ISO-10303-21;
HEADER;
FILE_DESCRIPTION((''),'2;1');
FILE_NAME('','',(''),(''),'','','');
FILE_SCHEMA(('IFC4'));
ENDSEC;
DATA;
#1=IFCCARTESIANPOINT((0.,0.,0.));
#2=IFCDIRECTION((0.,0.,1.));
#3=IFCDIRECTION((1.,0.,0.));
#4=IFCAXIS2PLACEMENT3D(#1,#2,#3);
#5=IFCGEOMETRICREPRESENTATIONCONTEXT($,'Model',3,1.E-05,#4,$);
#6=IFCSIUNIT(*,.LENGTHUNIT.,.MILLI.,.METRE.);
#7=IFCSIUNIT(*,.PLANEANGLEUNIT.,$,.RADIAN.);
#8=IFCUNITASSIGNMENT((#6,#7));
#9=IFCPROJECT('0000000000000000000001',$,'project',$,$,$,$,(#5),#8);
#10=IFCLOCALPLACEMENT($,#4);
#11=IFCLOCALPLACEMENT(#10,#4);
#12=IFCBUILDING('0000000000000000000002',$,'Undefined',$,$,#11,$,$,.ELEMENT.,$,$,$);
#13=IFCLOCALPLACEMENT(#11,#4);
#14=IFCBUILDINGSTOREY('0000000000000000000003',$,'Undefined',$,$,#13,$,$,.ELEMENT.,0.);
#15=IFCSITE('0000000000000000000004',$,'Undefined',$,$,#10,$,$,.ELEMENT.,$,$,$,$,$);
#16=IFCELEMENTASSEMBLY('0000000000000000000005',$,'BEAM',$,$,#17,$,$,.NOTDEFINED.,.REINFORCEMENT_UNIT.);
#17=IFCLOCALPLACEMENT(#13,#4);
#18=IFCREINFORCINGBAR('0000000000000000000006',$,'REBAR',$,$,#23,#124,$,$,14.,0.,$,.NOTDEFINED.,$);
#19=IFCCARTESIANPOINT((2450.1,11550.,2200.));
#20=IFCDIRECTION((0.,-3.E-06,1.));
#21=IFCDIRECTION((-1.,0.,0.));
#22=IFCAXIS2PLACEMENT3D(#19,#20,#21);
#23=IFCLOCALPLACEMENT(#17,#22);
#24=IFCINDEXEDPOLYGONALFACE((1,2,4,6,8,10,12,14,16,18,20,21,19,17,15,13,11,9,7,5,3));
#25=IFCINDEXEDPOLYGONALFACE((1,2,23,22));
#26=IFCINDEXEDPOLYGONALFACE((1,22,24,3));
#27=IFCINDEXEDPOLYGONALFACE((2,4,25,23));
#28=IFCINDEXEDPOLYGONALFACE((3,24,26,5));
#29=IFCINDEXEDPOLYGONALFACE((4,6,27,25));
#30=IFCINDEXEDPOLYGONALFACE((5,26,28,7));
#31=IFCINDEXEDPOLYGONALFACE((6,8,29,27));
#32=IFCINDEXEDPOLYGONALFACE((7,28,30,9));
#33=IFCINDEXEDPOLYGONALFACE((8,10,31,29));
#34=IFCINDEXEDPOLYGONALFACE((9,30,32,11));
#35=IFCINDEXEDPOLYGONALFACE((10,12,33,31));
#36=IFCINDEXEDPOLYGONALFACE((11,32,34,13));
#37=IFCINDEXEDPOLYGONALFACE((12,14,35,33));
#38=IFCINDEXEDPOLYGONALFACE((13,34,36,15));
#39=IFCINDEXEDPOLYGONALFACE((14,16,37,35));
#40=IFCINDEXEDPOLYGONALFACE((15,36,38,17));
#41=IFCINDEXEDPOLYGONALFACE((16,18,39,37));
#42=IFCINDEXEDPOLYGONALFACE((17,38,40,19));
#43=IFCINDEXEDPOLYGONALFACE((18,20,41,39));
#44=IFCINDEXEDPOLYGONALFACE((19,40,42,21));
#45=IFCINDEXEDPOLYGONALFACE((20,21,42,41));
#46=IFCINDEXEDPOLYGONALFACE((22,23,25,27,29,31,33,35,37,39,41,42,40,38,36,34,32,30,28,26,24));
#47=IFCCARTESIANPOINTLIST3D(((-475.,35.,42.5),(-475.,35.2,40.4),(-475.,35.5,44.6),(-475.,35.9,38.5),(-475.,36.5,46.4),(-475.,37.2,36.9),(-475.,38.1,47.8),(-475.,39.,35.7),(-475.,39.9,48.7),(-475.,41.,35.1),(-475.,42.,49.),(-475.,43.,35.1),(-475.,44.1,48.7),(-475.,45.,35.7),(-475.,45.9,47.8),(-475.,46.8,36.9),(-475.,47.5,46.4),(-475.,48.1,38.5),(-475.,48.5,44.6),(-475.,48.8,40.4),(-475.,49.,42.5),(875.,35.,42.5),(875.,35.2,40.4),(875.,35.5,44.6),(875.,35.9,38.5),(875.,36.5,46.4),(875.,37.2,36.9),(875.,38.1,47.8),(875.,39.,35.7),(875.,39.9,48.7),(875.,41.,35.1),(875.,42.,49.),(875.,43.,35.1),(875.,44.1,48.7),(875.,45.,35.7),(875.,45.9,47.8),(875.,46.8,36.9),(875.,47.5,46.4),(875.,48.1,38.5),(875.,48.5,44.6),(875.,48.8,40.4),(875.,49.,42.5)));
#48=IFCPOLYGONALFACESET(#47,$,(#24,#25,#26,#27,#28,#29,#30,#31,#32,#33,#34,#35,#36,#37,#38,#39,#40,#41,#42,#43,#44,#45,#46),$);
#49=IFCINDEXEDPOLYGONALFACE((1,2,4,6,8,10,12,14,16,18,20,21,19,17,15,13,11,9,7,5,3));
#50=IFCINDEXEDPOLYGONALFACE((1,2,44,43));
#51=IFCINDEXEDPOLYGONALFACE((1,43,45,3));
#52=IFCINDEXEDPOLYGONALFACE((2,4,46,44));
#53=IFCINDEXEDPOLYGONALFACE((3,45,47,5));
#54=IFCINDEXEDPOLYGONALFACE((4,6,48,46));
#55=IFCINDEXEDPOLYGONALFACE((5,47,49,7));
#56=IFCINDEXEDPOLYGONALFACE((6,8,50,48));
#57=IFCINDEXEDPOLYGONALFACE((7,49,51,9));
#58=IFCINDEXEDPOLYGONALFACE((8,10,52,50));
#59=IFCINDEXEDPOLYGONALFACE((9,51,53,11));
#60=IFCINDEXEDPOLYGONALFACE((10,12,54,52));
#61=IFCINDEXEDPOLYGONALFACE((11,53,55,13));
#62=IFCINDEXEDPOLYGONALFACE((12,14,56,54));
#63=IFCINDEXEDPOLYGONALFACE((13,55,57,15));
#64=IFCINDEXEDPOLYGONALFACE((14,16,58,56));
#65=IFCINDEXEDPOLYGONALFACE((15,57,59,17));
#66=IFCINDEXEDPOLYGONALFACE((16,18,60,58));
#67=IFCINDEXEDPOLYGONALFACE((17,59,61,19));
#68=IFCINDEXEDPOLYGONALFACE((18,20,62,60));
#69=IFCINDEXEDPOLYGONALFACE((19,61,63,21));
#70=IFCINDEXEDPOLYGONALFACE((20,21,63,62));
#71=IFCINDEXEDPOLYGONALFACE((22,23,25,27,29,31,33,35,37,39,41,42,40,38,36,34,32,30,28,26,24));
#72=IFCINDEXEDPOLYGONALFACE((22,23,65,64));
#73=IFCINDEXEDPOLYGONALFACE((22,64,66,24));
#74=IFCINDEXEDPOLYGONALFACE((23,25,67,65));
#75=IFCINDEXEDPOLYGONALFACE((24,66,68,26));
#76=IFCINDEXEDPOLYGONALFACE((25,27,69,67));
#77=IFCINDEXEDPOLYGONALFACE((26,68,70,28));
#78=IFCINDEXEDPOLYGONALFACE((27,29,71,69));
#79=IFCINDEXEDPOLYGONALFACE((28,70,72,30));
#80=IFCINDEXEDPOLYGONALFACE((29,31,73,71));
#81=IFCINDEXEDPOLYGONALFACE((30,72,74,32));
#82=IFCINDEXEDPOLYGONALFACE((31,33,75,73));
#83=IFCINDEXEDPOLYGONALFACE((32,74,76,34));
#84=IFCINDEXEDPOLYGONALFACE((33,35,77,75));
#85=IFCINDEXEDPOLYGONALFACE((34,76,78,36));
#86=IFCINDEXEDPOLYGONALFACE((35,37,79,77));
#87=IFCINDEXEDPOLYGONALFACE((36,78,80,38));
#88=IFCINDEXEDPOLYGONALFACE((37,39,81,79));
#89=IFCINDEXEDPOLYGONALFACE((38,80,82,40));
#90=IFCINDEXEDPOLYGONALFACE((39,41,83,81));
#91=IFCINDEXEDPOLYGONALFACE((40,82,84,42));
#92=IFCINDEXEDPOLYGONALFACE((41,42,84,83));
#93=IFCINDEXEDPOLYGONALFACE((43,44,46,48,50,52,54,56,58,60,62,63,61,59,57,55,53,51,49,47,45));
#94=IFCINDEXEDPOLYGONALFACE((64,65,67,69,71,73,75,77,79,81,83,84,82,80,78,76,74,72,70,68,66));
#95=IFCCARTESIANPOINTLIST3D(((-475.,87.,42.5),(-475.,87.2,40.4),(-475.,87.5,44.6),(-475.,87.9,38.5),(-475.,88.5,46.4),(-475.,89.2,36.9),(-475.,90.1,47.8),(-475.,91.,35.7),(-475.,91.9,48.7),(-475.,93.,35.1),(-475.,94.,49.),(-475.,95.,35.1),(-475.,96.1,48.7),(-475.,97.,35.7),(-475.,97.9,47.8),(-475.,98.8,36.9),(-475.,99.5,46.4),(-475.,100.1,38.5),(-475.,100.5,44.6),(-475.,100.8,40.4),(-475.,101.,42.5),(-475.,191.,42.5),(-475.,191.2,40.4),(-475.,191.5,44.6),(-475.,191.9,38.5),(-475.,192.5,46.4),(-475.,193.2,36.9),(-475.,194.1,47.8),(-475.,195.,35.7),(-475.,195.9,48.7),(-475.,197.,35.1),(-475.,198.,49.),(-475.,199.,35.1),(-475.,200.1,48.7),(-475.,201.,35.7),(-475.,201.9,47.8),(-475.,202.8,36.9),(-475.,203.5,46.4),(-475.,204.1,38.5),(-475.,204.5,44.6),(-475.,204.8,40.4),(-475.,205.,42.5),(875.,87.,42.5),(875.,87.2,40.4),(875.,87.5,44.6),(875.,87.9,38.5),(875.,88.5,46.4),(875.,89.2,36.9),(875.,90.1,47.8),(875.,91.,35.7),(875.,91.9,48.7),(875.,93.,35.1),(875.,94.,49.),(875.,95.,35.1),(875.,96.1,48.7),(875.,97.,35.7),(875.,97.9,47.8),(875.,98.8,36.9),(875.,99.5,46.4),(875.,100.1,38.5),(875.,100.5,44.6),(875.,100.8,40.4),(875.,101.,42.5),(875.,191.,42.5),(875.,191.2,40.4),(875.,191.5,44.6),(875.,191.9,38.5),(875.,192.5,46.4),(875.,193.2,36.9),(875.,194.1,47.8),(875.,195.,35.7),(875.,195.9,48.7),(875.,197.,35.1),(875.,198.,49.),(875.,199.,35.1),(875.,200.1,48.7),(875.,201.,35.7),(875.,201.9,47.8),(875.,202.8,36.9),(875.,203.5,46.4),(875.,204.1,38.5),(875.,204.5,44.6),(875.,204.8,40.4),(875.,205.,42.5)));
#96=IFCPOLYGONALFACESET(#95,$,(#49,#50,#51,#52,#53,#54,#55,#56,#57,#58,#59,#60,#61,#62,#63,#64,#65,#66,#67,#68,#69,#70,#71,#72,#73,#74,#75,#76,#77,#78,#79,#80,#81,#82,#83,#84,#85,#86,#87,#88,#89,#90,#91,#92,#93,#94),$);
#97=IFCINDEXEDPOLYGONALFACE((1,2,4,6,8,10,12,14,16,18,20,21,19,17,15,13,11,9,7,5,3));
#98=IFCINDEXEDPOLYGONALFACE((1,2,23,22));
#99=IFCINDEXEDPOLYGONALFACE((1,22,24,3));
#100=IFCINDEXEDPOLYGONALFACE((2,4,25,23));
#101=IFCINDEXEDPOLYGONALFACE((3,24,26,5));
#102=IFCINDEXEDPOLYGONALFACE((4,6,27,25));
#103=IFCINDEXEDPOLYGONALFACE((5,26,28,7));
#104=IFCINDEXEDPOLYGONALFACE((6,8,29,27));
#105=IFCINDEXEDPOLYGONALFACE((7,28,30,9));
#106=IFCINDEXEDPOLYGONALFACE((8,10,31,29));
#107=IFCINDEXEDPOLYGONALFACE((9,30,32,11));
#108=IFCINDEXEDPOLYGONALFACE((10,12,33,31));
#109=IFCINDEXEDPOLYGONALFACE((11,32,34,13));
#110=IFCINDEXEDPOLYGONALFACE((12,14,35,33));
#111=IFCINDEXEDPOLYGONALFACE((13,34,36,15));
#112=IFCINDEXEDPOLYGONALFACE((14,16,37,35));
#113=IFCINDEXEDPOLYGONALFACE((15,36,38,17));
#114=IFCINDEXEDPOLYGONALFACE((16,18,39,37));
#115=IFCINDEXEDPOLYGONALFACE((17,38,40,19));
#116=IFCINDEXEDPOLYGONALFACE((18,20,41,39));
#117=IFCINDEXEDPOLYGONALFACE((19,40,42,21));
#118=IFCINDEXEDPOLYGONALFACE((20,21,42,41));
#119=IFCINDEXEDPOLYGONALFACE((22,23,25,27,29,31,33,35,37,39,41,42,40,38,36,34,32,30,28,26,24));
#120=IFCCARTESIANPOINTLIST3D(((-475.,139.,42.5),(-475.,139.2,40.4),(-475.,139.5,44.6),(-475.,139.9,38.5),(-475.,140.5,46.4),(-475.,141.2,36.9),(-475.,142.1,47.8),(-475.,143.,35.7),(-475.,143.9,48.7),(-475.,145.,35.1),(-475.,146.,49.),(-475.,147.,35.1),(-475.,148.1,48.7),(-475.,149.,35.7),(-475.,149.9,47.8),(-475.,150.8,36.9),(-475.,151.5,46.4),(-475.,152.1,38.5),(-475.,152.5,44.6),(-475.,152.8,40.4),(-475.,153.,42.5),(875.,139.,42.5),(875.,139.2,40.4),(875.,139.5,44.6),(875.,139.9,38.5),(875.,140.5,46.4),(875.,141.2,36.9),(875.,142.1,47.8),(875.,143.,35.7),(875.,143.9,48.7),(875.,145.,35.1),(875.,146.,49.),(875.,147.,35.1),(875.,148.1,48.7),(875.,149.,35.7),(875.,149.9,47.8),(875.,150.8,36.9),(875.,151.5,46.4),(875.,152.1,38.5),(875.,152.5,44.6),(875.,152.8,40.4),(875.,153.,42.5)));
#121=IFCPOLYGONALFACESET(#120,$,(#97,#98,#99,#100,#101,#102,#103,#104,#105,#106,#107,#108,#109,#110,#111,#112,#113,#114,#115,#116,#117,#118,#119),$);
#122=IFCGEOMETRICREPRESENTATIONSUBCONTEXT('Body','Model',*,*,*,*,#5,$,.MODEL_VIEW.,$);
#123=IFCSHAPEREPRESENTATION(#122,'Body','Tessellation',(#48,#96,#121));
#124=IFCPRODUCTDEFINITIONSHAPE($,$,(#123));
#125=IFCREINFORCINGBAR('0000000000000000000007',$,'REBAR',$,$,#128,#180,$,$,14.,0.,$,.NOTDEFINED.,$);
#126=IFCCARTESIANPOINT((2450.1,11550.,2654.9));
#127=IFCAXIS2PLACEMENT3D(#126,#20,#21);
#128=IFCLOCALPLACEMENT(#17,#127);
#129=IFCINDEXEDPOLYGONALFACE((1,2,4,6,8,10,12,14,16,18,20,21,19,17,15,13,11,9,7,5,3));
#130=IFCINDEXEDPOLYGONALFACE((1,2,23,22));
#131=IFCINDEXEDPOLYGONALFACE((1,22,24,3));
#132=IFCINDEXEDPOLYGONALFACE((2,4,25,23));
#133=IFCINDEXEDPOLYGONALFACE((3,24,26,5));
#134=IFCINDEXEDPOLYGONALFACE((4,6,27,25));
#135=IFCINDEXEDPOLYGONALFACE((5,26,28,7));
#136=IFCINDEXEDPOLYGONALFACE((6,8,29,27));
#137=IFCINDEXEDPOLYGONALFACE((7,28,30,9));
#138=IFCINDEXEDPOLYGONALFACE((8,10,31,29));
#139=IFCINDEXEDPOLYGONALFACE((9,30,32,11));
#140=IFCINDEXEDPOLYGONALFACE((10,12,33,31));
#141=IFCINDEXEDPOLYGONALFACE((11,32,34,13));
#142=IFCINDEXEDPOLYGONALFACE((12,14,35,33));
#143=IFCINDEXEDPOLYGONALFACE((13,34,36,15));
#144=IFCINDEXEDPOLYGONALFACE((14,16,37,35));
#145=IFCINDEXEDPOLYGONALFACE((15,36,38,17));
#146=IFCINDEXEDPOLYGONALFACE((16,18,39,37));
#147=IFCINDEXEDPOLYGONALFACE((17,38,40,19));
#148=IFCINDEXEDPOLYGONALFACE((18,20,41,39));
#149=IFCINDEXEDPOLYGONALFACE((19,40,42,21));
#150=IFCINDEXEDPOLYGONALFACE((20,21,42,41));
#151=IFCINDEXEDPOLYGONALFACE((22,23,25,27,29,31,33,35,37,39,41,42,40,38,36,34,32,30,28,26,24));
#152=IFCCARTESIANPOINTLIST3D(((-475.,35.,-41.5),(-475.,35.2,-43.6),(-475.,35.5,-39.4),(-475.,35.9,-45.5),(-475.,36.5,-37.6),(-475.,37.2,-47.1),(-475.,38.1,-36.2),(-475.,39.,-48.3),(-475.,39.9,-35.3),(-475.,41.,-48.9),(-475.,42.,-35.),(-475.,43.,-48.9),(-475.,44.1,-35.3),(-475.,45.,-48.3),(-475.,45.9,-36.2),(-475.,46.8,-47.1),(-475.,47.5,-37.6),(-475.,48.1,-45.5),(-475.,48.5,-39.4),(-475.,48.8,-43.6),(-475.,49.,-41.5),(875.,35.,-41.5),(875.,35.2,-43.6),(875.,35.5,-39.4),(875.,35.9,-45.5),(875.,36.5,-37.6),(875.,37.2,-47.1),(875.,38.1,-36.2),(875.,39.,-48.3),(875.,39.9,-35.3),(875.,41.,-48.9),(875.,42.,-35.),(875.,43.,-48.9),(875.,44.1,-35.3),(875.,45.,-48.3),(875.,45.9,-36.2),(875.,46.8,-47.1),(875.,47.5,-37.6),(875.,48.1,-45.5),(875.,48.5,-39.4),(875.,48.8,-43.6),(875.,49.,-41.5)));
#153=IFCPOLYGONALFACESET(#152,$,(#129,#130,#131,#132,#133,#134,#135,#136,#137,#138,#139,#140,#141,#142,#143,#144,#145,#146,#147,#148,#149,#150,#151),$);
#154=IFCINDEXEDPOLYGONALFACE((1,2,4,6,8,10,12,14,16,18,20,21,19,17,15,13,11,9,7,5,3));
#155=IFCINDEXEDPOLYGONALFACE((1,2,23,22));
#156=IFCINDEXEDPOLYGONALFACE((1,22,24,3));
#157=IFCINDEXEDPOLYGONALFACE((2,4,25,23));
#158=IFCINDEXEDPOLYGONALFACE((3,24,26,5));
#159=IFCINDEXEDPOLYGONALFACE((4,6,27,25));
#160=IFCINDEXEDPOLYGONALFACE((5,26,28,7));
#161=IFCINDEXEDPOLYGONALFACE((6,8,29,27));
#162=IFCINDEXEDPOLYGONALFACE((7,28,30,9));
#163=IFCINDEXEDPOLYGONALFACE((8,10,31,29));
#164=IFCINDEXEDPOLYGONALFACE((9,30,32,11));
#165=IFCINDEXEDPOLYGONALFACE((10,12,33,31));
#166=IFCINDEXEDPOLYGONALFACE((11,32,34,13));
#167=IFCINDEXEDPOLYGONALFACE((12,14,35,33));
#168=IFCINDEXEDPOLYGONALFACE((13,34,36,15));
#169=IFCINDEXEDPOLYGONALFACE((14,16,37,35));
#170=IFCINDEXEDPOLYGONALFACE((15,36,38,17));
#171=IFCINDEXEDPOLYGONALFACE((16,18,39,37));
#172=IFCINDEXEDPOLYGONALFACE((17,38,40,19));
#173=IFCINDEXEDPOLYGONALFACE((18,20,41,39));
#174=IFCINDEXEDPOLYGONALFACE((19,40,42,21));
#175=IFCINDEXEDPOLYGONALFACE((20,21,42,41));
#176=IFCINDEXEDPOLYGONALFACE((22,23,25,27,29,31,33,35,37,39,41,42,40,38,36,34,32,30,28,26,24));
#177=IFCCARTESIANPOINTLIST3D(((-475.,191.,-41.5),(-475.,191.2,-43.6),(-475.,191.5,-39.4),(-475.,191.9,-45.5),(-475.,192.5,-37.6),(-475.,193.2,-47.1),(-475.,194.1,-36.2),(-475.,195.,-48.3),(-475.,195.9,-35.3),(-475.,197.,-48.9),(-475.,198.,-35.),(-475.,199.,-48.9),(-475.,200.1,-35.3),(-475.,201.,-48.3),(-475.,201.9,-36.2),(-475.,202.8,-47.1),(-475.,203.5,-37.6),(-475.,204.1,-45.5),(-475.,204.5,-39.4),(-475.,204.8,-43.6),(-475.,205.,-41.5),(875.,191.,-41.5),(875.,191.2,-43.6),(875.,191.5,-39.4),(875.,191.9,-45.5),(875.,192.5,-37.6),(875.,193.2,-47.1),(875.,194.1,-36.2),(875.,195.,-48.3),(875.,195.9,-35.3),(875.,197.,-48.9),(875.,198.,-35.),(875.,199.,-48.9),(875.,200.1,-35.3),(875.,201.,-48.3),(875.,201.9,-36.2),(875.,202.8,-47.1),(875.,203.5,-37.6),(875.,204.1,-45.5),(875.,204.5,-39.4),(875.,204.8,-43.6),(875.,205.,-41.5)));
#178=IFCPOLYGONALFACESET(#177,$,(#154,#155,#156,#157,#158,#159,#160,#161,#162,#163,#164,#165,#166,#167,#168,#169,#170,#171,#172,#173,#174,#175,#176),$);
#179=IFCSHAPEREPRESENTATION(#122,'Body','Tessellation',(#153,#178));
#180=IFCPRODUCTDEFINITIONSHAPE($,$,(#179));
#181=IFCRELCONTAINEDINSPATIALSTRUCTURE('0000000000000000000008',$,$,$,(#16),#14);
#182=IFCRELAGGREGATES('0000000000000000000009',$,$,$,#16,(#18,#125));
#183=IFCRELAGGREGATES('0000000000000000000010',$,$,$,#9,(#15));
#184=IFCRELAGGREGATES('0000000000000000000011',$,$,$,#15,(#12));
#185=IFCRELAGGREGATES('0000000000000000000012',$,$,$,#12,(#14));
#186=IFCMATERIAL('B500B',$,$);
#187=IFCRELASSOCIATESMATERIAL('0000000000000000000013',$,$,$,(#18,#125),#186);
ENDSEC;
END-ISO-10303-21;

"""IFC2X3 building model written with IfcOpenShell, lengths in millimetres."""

from ifc_helpers import new_model, entity, si_unit, frame, origin_with_axes, place, context, subcontext, project, spatial, source, transform, mapped, material, element, aggregate, save


model = new_model("IFC2X3")

# Units and contexts
model_context = context("Model", 3, precision=1e-05, world=origin_with_axes())
body_context = subcontext(model_context, "Body", "Model", "MODEL_VIEW")
ifc_project = project(units=[si_unit("LENGTHUNIT", "METRE", prefix="MILLI"), si_unit("PLANEANGLEUNIT", "RADIAN")], contexts=[model_context])

# Site, building, storey
site_placement = place(None, origin_with_axes())
site = spatial("IfcSite", under=ifc_project, at=site_placement, Name="Undefined", CompositionType="ELEMENT")
building_placement = place(site_placement, origin_with_axes())
building = spatial("IfcBuilding", under=site, at=building_placement, Name="Undefined", CompositionType="ELEMENT")
storey_placement = place(building_placement, origin_with_axes())
storey = spatial("IfcBuildingStorey", under=building, at=storey_placement, Name="Undefined", CompositionType="ELEMENT", Elevation=0.0)

# Element assembly
assembly_1_placement = place(storey_placement, origin_with_axes())
assembly_1 = element("IfcElementAssembly", 1, at=assembly_1_placement, inside=storey, Name="BEAM", AssemblyPlace="NOTDEFINED", PredefinedType="REINFORCEMENT_UNIT")

# Reinforcing bars
ifc_material_1 = material(Name="B500B")
shared_shape_1 = source(origin_with_axes(), body_context, "Body", "AdvancedSweptSolid", [
    entity("IfcSweptDiskSolid", entity("IfcTrimmedCurve", entity("IfcLine", entity("IfcCartesianPoint", [0.0, 0.0, 0.0]), entity("IfcVector", entity("IfcDirection", [1.0, 0.0, 0.0]), 1.0)), [entity("IfcParameterValue", 0.0)], [entity("IfcParameterValue", 1349.999613)], True, "PARAMETER"), 7.0, None, 0.0, 1350.0),
])
shared_shape_2 = source(origin_with_axes(), body_context, "Body", "AdvancedSweptSolid", [
    entity("IfcSweptDiskSolid", entity("IfcTrimmedCurve", entity("IfcLine", entity("IfcCartesianPoint", [0.0, 0.0, 0.0]), entity("IfcVector", entity("IfcDirection", [1.0, 0.0, 0.0]), 1.0)), [entity("IfcParameterValue", 0.0)], [entity("IfcParameterValue", 1349.999613)], True, "PARAMETER"), 7.0, None, 0.0, 1350.0),
])
shared_shape_3 = source(origin_with_axes(), body_context, "Body", "AdvancedSweptSolid", [
    entity("IfcSweptDiskSolid", entity("IfcTrimmedCurve", entity("IfcLine", entity("IfcCartesianPoint", [0.0, 0.0, 0.0]), entity("IfcVector", entity("IfcDirection", [1.0, 0.0, 0.0]), 1.0)), [entity("IfcParameterValue", 0.0)], [entity("IfcParameterValue", 1349.999613)], True, "PARAMETER"), 7.0, None, 0.0, 1350.0),
])
shared_shape_4 = source(origin_with_axes(), body_context, "Body", "AdvancedSweptSolid", [
    entity("IfcSweptDiskSolid", entity("IfcTrimmedCurve", entity("IfcLine", entity("IfcCartesianPoint", [0.0, 0.0, 0.0]), entity("IfcVector", entity("IfcDirection", [1.0, 0.0, 0.0]), 1.0)), [entity("IfcParameterValue", 0.0)], [entity("IfcParameterValue", 1349.999613)], True, "PARAMETER"), 7.0, None, 0.0, 1350.0),
])
reinforcing_bar_1_placement = place(assembly_1_placement, frame((2450.1, 11550.0, 2200.0), z_axis=(0.0, -0.000003, 1.0), x_axis=(-1.0, 0.0, 0.0)))
reinforcing_bar_1 = element("IfcReinforcingBar", 2, at=reinforcing_bar_1_placement, material=ifc_material_1, Name="REBAR", BarRole="NOTDEFINED", CrossSectionArea=0.0, NominalDiameter=14.0, context=body_context, shape_type="MappedRepresentation", body=[
    mapped(shared_shape_1, transform((-475.0, 42.0, 42.0))),
    mapped(shared_shape_2, transform((-475.0, 94.0, 42.0))),
    mapped(shared_shape_3, transform((-475.0, 146.0, 42.0))),
    mapped(shared_shape_4, transform((-475.0, 198.0, 42.0))),
])
shared_shape_5 = source(origin_with_axes(), body_context, "Body", "AdvancedSweptSolid", [
    entity("IfcSweptDiskSolid", entity("IfcTrimmedCurve", entity("IfcLine", entity("IfcCartesianPoint", [0.0, 0.0, 0.0]), entity("IfcVector", entity("IfcDirection", [1.0, 0.0, 0.0]), 1.0)), [entity("IfcParameterValue", 0.0)], [entity("IfcParameterValue", 1349.999613)], True, "PARAMETER"), 7.0, None, 0.0, 1350.0),
])
shared_shape_6 = source(origin_with_axes(), body_context, "Body", "AdvancedSweptSolid", [
    entity("IfcSweptDiskSolid", entity("IfcTrimmedCurve", entity("IfcLine", entity("IfcCartesianPoint", [0.0, 0.0, 0.0]), entity("IfcVector", entity("IfcDirection", [1.0, 0.0, 0.0]), 1.0)), [entity("IfcParameterValue", 0.0)], [entity("IfcParameterValue", 1349.999613)], True, "PARAMETER"), 7.0, None, 0.0, 1350.0),
])
reinforcing_bar_2_placement = place(assembly_1_placement, frame((2450.1, 11550.0, 2654.9), z_axis=(0.0, -0.000003, 1.0), x_axis=(-1.0, 0.0, 0.0)))
reinforcing_bar_2 = element("IfcReinforcingBar", 3, at=reinforcing_bar_2_placement, material=ifc_material_1, Name="REBAR", BarRole="NOTDEFINED", CrossSectionArea=0.0, NominalDiameter=14.0, context=body_context, shape_type="MappedRepresentation", body=[
    mapped(shared_shape_5, transform((-475.0, 42.0, -42.0))),
    mapped(shared_shape_6, transform((-475.0, 198.0, -42.0))),
])
aggregate(assembly_1, [reinforcing_bar_1, reinforcing_bar_2])

save(model, "model.ifc")
